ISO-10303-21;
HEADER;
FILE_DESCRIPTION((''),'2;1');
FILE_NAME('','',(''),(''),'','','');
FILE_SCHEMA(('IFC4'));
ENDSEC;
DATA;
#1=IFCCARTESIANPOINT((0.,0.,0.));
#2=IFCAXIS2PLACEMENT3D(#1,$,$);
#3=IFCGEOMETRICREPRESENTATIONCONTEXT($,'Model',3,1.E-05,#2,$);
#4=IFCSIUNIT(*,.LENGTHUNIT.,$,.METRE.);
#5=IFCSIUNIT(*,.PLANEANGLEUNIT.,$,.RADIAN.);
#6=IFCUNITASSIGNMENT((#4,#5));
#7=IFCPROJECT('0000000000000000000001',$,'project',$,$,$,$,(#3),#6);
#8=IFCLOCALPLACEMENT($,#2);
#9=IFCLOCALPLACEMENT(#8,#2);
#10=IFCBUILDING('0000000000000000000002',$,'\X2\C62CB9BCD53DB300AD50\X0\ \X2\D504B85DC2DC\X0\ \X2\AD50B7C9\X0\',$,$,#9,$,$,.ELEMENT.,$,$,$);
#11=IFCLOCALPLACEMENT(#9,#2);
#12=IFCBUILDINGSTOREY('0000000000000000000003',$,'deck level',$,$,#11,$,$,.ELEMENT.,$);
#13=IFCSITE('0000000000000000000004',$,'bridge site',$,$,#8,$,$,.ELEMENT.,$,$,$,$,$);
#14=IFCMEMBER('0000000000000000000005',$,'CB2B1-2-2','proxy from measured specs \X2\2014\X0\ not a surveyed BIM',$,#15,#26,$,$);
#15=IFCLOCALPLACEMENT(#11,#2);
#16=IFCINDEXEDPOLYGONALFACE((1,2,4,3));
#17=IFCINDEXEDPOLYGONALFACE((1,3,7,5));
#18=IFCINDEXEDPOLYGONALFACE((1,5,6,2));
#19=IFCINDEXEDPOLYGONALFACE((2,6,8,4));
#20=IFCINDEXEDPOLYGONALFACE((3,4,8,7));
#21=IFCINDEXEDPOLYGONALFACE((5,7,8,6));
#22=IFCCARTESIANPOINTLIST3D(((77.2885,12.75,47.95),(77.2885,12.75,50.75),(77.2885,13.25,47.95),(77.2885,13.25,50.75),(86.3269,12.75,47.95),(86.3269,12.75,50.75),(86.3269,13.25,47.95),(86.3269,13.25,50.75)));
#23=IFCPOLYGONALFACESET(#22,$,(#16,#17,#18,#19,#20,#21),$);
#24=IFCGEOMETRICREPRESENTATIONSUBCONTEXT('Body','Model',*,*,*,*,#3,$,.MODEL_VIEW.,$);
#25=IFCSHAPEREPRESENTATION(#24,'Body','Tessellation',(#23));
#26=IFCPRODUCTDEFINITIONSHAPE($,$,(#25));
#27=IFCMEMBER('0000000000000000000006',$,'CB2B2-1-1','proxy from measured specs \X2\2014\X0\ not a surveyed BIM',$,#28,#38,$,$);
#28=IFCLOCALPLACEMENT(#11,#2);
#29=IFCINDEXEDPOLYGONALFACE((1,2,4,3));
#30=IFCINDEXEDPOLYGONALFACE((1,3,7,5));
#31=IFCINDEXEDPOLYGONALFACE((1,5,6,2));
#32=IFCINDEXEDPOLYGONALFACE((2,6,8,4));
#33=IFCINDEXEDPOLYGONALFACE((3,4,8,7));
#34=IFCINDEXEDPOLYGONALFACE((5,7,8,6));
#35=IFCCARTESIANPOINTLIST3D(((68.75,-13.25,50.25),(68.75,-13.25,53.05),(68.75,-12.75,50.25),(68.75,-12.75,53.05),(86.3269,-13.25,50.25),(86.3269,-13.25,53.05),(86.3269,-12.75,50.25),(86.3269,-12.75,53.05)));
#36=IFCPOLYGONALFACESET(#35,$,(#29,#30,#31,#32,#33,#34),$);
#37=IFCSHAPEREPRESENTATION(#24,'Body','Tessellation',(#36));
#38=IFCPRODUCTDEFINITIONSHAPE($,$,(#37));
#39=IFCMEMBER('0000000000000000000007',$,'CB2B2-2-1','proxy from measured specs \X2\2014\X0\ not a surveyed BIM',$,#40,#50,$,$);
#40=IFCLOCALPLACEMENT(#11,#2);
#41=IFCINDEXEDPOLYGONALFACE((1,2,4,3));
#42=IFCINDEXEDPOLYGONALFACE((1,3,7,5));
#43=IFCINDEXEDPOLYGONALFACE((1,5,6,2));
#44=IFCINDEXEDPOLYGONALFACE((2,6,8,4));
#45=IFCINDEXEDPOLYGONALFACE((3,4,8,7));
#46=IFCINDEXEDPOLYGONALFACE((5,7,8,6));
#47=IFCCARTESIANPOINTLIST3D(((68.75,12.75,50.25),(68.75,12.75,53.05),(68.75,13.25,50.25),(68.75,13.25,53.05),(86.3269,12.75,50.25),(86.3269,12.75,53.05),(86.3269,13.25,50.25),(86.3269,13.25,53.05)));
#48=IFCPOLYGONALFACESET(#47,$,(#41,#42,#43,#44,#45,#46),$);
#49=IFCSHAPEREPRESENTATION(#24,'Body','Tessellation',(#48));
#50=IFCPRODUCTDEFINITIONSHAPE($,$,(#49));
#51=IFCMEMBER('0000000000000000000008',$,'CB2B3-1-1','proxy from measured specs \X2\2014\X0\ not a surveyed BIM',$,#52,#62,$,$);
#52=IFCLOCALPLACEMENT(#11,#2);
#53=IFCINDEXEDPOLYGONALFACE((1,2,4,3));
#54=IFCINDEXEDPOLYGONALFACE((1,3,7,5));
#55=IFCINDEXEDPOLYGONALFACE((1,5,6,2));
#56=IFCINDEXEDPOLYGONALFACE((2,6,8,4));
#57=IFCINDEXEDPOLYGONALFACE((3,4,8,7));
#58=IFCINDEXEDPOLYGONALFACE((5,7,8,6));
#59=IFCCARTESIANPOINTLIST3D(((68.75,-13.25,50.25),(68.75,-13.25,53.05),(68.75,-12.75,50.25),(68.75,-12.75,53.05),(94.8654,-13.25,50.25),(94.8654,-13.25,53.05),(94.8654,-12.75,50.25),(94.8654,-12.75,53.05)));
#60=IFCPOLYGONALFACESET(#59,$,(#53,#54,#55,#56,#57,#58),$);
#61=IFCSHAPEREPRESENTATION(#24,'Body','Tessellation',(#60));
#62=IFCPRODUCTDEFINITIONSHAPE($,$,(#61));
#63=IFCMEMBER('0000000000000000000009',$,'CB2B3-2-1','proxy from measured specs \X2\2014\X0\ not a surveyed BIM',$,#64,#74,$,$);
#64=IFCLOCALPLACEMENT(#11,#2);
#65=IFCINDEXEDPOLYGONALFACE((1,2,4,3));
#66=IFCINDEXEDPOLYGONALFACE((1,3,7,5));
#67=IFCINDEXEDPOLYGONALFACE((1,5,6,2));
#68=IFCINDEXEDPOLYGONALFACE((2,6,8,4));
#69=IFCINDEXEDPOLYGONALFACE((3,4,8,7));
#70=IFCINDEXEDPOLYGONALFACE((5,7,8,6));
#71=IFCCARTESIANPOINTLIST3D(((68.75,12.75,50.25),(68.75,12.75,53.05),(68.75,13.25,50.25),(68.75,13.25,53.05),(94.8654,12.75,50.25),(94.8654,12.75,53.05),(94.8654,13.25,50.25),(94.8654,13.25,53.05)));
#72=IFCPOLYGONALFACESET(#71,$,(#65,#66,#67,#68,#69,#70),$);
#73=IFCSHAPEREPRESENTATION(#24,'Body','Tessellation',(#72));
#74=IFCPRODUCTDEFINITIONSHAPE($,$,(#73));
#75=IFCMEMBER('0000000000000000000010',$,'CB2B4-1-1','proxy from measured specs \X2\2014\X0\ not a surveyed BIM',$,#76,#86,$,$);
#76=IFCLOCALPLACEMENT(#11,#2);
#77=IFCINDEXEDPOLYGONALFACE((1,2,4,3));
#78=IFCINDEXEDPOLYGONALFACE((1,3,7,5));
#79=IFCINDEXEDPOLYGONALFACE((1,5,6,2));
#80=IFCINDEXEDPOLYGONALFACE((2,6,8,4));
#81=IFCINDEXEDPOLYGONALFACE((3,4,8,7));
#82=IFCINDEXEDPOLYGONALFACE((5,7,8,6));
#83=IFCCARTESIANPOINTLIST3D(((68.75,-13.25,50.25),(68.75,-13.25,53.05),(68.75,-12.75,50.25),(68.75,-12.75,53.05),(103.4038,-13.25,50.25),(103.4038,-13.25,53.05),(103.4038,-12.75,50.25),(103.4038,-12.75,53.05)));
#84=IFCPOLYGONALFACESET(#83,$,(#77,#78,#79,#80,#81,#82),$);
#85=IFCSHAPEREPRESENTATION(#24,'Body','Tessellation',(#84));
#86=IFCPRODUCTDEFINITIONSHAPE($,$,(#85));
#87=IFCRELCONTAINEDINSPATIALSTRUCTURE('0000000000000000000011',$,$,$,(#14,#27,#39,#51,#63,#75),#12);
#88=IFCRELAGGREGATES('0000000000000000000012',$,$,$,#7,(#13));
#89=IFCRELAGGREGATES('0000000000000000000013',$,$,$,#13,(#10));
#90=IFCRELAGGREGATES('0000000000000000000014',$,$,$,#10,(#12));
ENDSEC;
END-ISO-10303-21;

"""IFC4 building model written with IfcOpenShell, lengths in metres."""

from ifc_helpers import new_model, si_unit, frame, origin, origin_2d, place, context, subcontext, project, spatial, rectangle, extrude, element, save


model = new_model("IFC4")

# Units and contexts
model_context = context("Model", 3, precision=1e-05, world=origin())
body_context = subcontext(model_context, "Body", "Model", "MODEL_VIEW")
ifc_project = project(units=[si_unit("LENGTHUNIT", "METRE"), si_unit("PLANEANGLEUNIT", "RADIAN")], contexts=[model_context])

# Site, building, storey
site_placement = place(None, origin())
site = spatial("IfcSite", under=ifc_project, at=site_placement, Name="bridge site", CompositionType="ELEMENT")
building_placement = place(site_placement, origin())
building = spatial("IfcBuilding", under=site, at=building_placement, Name="올림픽대교 프록시 교량", CompositionType="ELEMENT")
storey_placement = place(building_placement, origin())
storey = spatial("IfcBuildingStorey", under=building, at=storey_placement, Name="deck level", CompositionType="ELEMENT")

# Members
member_1_placement = place(storey_placement, frame((81.8077, 13.0, 47.95)))
element("IfcMember", 1, at=member_1_placement, inside=storey, Name="CB2B1-2-2", Description="proxy from measured specs — not a surveyed BIM", context=body_context, shape_type="SweptSolid", body=[
    extrude(rectangle(XDim=9.0385, YDim=0.5, at=origin_2d()), origin(), (0.0, 0.0, 1.0), 2.8),
])
for number, where, name in (
    (2, (77.5385, -13.0, 50.25), "CB2B2-1-1"),
    (3, (77.5385, 13.0, 50.25), "CB2B2-2-1"),
):
    element("IfcMember", number, at=place(storey_placement, frame(where)), inside=storey, Name=name, Description="proxy from measured specs — not a surveyed BIM", context=body_context, shape_type="SweptSolid", body=[
        extrude(rectangle(XDim=17.5769, YDim=0.5, at=origin_2d()), origin(), (0.0, 0.0, 1.0), 2.8),
    ])
for number, where, name in (
    (4, (81.8077, -13.0, 50.25), "CB2B3-1-1"),
    (5, (81.8077, 13.0, 50.25), "CB2B3-2-1"),
):
    element("IfcMember", number, at=place(storey_placement, frame(where)), inside=storey, Name=name, Description="proxy from measured specs — not a surveyed BIM", context=body_context, shape_type="SweptSolid", body=[
        extrude(rectangle(XDim=26.1154, YDim=0.5, at=origin_2d()), origin(), (0.0, 0.0, 1.0), 2.8),
    ])
member_2_placement = place(storey_placement, frame((86.0769, -13.0, 50.25)))
element("IfcMember", 6, at=member_2_placement, inside=storey, Name="CB2B4-1-1", Description="proxy from measured specs — not a surveyed BIM", context=body_context, shape_type="SweptSolid", body=[
    extrude(rectangle(XDim=34.6538, YDim=0.5, at=origin_2d()), origin(), (0.0, 0.0, 1.0), 2.8),
])

save(model, "model.ifc")
